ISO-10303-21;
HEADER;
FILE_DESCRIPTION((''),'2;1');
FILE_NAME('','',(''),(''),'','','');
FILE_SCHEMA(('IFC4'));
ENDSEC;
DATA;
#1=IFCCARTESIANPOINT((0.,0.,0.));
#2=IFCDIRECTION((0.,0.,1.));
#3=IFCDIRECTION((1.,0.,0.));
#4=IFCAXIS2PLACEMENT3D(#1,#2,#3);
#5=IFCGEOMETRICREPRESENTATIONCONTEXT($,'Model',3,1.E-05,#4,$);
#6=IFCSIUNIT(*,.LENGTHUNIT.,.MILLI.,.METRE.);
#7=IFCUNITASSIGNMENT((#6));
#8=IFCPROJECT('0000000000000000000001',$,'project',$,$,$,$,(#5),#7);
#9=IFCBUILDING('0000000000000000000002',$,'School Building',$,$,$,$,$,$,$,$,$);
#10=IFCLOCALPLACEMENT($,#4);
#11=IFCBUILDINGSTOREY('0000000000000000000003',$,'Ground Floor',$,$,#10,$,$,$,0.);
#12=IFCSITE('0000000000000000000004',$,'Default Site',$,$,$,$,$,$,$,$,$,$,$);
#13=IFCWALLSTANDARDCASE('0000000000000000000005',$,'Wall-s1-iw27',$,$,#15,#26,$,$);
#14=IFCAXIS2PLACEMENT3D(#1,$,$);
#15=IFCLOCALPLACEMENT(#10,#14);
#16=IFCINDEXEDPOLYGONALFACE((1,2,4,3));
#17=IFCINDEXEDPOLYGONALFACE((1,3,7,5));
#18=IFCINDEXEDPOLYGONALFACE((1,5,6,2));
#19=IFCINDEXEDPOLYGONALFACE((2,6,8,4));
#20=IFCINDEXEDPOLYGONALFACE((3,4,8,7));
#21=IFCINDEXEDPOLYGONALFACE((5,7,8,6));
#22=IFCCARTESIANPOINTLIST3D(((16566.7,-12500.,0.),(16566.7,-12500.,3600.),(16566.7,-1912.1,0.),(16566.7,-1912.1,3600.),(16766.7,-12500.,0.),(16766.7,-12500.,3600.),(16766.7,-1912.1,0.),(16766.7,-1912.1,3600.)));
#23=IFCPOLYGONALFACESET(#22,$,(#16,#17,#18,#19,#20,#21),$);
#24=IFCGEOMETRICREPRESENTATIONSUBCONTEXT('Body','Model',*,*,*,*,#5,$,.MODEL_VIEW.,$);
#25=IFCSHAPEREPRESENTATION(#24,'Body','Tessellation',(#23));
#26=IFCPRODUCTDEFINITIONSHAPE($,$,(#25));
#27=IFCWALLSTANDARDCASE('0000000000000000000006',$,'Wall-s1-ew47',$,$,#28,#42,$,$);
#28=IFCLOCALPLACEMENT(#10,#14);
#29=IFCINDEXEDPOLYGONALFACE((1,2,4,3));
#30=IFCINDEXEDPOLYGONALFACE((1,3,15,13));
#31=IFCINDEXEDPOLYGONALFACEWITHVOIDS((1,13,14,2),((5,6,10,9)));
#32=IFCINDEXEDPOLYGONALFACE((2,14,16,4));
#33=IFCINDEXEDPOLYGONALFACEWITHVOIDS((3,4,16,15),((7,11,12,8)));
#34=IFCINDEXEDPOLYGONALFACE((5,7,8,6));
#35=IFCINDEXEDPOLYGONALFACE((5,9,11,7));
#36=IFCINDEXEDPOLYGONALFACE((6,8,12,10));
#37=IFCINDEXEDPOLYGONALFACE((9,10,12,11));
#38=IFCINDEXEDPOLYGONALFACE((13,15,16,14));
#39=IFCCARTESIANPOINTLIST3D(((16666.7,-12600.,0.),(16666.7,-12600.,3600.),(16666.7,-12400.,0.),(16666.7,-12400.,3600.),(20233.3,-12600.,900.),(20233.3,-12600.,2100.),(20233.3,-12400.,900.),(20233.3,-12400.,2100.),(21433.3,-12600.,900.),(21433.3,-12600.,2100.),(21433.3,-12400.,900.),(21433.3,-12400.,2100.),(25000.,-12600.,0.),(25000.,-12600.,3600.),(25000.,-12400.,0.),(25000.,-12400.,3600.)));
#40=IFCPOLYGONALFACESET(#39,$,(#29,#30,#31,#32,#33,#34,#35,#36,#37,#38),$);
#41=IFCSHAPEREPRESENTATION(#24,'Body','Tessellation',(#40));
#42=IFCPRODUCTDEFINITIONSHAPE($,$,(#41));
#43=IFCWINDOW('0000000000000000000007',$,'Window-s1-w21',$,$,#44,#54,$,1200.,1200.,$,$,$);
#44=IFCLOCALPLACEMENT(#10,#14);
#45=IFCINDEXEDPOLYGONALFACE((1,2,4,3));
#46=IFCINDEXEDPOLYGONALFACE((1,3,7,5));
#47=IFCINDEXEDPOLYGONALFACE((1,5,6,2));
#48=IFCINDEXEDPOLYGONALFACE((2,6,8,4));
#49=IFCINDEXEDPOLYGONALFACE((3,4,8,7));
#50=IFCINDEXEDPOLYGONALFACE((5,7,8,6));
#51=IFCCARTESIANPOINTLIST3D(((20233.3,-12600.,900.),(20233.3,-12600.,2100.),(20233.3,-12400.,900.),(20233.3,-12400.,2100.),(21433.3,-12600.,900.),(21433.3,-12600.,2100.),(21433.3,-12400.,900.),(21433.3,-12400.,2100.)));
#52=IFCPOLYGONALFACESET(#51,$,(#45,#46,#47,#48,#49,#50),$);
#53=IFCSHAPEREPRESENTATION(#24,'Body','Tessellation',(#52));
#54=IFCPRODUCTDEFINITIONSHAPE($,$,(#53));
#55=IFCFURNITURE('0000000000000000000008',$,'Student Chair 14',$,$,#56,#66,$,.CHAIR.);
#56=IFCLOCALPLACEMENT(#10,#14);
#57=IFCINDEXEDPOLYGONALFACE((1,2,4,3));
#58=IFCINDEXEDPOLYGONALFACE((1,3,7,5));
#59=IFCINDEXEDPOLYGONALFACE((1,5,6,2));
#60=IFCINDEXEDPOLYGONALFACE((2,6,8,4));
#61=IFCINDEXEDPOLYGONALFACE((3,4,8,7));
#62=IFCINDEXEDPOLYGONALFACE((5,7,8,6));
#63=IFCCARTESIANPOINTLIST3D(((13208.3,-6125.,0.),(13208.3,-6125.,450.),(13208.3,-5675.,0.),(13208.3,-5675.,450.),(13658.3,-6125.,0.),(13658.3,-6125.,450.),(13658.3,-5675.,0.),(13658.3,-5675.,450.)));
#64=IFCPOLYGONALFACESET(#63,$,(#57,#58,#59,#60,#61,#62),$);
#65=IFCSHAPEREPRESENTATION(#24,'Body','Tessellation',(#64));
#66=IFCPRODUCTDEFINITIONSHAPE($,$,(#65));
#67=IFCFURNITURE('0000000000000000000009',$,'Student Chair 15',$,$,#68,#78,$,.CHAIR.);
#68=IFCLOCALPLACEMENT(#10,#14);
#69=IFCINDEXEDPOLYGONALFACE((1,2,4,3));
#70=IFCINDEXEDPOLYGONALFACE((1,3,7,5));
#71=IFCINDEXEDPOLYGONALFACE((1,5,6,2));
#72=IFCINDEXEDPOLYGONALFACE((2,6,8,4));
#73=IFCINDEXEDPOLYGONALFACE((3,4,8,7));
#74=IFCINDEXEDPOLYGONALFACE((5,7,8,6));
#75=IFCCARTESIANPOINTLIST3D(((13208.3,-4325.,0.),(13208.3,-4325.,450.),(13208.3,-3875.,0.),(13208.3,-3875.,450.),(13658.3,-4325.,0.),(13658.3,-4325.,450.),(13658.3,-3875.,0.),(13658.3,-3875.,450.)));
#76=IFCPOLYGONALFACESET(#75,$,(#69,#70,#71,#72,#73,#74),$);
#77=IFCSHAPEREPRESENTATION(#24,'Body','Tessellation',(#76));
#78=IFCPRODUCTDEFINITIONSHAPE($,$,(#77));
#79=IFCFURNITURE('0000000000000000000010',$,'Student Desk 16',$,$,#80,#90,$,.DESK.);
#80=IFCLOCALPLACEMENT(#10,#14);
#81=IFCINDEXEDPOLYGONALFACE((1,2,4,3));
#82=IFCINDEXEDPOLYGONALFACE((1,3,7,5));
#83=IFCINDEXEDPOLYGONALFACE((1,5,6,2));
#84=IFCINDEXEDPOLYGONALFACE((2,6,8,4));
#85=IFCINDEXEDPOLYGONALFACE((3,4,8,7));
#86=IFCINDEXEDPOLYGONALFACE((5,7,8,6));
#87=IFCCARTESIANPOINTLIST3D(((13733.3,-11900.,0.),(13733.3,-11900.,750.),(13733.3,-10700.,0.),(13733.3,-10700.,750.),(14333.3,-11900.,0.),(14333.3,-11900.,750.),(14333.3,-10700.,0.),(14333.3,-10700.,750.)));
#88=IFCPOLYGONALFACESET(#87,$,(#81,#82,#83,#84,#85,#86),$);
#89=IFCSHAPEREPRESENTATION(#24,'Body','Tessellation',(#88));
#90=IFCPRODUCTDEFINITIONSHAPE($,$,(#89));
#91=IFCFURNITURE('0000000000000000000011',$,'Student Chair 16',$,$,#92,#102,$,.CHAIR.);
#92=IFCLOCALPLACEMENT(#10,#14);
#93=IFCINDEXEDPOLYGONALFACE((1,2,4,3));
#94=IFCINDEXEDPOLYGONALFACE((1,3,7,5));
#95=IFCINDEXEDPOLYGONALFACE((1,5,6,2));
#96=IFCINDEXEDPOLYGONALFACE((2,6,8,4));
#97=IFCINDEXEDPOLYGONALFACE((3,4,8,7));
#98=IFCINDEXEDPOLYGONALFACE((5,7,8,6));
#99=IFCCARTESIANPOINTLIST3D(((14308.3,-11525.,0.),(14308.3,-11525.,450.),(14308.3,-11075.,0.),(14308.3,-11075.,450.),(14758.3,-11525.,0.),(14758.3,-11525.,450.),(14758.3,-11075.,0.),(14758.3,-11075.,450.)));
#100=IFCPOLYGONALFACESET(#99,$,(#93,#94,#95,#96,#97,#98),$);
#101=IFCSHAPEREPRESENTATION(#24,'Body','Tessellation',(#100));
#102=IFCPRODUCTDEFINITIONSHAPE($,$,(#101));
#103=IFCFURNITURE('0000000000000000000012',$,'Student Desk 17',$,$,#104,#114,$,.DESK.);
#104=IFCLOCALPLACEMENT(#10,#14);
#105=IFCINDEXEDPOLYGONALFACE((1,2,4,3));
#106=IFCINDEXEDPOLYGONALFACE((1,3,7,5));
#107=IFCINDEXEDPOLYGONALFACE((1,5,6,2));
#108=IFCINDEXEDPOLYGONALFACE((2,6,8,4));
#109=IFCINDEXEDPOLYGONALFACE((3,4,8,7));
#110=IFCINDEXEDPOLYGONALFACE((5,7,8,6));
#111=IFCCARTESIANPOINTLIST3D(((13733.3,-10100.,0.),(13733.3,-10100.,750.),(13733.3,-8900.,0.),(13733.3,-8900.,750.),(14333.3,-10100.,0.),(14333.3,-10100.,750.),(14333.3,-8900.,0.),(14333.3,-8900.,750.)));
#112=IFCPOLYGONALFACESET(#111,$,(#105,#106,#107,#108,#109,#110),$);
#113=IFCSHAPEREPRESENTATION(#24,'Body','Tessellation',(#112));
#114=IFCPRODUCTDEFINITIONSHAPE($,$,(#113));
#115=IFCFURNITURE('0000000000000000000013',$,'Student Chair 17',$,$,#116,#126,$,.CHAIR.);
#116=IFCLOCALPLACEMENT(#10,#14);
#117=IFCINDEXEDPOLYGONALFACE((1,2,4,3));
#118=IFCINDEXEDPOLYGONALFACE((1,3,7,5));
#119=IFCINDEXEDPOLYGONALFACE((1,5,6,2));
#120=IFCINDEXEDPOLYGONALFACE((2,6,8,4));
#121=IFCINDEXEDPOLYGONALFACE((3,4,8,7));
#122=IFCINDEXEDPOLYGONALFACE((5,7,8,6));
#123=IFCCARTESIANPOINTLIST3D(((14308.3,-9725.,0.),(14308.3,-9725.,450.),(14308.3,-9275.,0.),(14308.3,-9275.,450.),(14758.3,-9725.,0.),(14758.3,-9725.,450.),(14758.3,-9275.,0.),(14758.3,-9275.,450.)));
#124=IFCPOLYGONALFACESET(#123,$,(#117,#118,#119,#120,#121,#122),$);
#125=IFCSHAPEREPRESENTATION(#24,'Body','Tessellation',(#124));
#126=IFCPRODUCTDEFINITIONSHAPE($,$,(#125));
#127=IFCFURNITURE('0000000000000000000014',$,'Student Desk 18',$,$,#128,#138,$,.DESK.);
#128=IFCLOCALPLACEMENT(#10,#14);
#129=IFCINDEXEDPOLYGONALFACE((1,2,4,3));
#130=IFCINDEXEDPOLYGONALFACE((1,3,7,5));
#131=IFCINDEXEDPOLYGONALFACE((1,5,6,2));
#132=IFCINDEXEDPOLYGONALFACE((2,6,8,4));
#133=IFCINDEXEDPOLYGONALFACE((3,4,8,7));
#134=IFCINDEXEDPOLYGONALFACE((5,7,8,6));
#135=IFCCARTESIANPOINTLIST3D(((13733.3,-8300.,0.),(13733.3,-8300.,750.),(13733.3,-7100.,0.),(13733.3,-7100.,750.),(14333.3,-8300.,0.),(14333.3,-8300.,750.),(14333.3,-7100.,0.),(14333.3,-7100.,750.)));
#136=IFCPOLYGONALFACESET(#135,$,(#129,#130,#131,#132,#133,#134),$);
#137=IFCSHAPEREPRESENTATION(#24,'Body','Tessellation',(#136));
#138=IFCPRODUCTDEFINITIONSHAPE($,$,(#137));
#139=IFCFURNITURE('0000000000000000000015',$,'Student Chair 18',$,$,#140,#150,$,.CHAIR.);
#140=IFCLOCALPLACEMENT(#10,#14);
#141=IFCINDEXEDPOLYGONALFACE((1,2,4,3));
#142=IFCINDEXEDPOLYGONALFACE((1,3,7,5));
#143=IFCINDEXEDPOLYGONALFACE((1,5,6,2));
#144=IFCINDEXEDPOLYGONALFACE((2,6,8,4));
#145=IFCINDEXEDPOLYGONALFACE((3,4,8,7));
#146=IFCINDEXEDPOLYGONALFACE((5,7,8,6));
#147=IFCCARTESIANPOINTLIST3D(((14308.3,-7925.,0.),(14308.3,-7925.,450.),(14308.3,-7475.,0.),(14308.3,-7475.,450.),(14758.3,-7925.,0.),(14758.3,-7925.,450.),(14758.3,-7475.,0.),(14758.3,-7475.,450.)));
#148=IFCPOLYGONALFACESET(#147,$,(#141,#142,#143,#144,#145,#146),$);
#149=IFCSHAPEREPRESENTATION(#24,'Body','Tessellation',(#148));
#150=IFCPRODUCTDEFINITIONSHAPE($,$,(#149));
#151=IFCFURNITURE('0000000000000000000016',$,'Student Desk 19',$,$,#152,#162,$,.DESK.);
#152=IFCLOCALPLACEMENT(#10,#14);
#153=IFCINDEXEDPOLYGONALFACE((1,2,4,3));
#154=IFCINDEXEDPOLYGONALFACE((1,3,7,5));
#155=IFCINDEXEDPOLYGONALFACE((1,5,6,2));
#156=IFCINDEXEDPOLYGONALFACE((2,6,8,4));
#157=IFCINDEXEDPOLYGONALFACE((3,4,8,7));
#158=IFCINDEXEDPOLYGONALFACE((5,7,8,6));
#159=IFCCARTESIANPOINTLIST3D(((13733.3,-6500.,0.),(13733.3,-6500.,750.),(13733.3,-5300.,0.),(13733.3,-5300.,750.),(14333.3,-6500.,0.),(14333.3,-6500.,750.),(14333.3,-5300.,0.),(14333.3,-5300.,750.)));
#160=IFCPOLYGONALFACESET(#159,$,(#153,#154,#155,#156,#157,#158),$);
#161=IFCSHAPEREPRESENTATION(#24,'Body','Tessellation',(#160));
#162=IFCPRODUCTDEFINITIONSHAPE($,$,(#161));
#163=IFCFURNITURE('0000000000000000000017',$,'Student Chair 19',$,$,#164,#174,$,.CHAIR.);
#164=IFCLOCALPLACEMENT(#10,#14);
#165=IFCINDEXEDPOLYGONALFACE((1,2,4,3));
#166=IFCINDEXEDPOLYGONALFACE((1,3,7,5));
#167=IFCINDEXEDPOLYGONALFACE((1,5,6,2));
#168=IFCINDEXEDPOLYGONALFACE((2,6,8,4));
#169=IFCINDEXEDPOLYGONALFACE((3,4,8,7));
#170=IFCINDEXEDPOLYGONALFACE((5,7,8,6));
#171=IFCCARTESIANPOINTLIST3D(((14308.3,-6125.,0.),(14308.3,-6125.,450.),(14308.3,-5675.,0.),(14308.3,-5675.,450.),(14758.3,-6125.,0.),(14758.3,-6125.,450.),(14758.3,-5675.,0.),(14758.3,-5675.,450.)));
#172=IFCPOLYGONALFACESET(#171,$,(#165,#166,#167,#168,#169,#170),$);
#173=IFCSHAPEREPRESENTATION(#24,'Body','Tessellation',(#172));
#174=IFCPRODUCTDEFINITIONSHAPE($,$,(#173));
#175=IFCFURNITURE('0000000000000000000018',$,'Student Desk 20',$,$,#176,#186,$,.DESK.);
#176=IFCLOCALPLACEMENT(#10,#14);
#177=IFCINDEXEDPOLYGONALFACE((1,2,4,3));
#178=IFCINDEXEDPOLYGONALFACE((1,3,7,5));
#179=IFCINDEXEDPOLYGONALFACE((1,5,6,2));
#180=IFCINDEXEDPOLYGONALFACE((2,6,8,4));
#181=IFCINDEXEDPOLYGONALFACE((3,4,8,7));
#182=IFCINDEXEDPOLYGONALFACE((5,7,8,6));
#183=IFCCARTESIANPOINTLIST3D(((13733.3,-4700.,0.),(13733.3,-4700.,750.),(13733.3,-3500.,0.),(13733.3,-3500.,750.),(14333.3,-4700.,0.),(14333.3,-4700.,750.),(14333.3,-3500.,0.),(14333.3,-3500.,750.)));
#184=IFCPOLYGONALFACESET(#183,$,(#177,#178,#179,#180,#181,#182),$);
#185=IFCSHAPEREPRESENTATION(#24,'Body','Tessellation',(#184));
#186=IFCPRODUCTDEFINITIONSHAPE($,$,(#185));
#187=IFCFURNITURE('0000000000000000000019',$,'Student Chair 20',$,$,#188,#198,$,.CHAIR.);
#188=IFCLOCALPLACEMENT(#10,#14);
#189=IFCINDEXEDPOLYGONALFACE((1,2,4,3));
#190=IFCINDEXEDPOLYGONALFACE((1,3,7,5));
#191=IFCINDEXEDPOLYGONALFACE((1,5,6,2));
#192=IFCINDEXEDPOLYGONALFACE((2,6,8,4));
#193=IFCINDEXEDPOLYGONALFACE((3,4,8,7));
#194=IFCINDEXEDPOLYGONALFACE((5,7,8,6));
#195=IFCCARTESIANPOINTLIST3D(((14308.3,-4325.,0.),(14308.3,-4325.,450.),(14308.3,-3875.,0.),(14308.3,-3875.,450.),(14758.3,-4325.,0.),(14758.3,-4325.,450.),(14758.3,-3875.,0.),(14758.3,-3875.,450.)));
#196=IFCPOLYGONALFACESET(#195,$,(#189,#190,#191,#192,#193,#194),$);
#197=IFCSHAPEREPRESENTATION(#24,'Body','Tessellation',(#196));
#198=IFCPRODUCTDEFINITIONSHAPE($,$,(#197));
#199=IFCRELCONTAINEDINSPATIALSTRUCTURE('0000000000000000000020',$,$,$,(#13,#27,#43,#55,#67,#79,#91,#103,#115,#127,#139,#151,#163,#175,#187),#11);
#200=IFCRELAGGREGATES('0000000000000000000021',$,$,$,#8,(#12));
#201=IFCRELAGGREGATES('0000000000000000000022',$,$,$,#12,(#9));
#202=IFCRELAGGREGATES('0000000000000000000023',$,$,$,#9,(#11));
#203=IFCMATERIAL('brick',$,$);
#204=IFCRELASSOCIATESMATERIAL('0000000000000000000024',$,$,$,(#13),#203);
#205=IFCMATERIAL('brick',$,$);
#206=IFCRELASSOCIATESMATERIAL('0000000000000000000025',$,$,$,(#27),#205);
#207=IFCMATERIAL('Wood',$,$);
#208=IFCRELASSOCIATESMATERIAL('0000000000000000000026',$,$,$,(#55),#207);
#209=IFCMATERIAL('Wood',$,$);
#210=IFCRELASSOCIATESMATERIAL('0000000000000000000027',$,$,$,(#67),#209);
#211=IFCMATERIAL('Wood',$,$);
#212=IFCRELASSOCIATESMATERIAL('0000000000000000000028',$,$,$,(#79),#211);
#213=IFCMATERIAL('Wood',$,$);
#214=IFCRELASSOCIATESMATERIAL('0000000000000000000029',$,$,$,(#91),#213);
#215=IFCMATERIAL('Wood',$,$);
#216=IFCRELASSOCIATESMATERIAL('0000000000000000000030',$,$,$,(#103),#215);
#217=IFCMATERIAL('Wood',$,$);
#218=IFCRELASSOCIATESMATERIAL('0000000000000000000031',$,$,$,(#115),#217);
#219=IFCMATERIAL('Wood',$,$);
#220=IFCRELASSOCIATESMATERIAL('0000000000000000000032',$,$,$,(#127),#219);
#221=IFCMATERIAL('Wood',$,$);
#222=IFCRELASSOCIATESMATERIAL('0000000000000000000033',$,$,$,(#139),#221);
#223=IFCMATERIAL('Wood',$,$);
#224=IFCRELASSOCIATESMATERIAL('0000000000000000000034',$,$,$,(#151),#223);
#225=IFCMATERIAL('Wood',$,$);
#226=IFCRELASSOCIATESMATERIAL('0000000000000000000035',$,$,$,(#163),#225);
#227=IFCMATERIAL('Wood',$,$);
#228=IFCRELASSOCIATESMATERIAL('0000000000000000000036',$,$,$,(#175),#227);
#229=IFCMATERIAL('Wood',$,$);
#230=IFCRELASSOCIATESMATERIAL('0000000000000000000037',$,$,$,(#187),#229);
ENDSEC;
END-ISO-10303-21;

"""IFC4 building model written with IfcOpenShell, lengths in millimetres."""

from ifc_helpers import new_model, si_unit, frame, frame_2d, origin_with_axes, origin_2d, place, context, subcontext, project, spatial, rectangle, extrude, material, element, fill, save


model = new_model("IFC4")

# Units and contexts
model_context = context("Model", 3, precision=1e-05, world=origin_with_axes())
body_context = subcontext(model_context, "Body", "Model", "MODEL_VIEW")
ifc_project = project(units=[si_unit("LENGTHUNIT", "METRE", prefix="MILLI")], contexts=[model_context])

# Site, building, storey
site = spatial("IfcSite", under=ifc_project, Name="Default Site")
building = spatial("IfcBuilding", under=site, Name="School Building")
storey_placement = place(None, origin_with_axes())
storey = spatial("IfcBuildingStorey", under=building, at=storey_placement, Name="Ground Floor", Elevation=0.0)

# Wall
ifc_material_1 = material(Name="brick")
wall_1_placement = place(storey_placement, frame((16666.7, -12500.0, 0.0), z_axis=(0.0, 0.0, 1.0), x_axis=(0.0, 1.0, 0.0)))
element("IfcWallStandardCase", 1, at=wall_1_placement, inside=storey, material=ifc_material_1, Name="Wall-s1-iw27", context=body_context, shape_type="SweptSolid", body=[
    extrude(rectangle(XDim=10587.9, YDim=200.0, at=frame_2d((5293.9, 0.0))), origin_with_axes(), (0.0, 0.0, 1.0), 3600.0),
])

# Wall, opening, window
ifc_material_2 = material(Name="brick")
wall_2_placement = place(storey_placement, frame((16666.7, -12500.0, 0.0), z_axis=(0.0, 0.0, 1.0), x_axis=(1.0, 0.0, 0.0)))
wall_2 = element("IfcWallStandardCase", 2, at=wall_2_placement, inside=storey, material=ifc_material_2, Name="Wall-s1-ew47", context=body_context, shape_type="SweptSolid", body=[
    extrude(rectangle(XDim=8333.3, YDim=200.0, at=frame_2d((4166.7, 0.0))), origin_with_axes(), (0.0, 0.0, 1.0), 3600.0),
])
opening_placement = place(wall_2_placement, frame((3566.7, 0.0, 900.0), z_axis=(0.0, 0.0, 1.0), x_axis=(1.0, 0.0, 0.0)))
opening = element("IfcOpeningElement", 3, at=opening_placement, cuts=wall_2, context=body_context, shape_type="SweptSolid", body=[
    extrude(rectangle(XDim=1200.0, YDim=400.0, at=frame_2d((600.0, 0.0))), origin_with_axes(), (0.0, 0.0, 1.0), 1200.0),
])
window_placement = place(storey_placement, frame((20233.3, -12500.0, 900.0), z_axis=(0.0, 0.0, 1.0), x_axis=(1.0, 0.0, 0.0)))
window = element("IfcWindow", 4, at=window_placement, inside=storey, Name="Window-s1-w21", OverallHeight=1200.0, OverallWidth=1200.0, context=body_context, shape_type="SweptSolid", body=[
    extrude(rectangle(XDim=1200.0, YDim=200.0, at=frame_2d((600.0, 0.0))), origin_with_axes(), (0.0, 0.0, 1.0), 1200.0),
])
fill(opening, window)

# Furniture
ifc_material_3 = material(Name="Wood")
furniture_1_placement = place(storey_placement, frame((13433.3, -5900.0, 0.0), z_axis=(0.0, 0.0, 1.0), x_axis=(1.0, 0.0, 0.0)))
element("IfcFurniture", 5, at=furniture_1_placement, inside=storey, material=ifc_material_3, Name="Student Chair 14", PredefinedType="CHAIR", context=body_context, shape_type="SweptSolid", body=[
    extrude(rectangle(XDim=450.0, YDim=450.0, at=origin_2d()), origin_with_axes(), (0.0, 0.0, 1.0), 450.0),
])
ifc_material_4 = material(Name="Wood")
furniture_2_placement = place(storey_placement, frame((13433.3, -4100.0, 0.0), z_axis=(0.0, 0.0, 1.0), x_axis=(1.0, 0.0, 0.0)))
element("IfcFurniture", 6, at=furniture_2_placement, inside=storey, material=ifc_material_4, Name="Student Chair 15", PredefinedType="CHAIR", context=body_context, shape_type="SweptSolid", body=[
    extrude(rectangle(XDim=450.0, YDim=450.0, at=origin_2d()), origin_with_axes(), (0.0, 0.0, 1.0), 450.0),
])
ifc_material_5 = material(Name="Wood")
furniture_3_placement = place(storey_placement, frame((14033.3, -11300.0, 0.0), z_axis=(0.0, 0.0, 1.0), x_axis=(0.0, 1.0, 0.0)))
element("IfcFurniture", 7, at=furniture_3_placement, inside=storey, material=ifc_material_5, Name="Student Desk 16", PredefinedType="DESK", context=body_context, shape_type="SweptSolid", body=[
    extrude(rectangle(XDim=1200.0, YDim=600.0, at=origin_2d()), origin_with_axes(), (0.0, 0.0, 1.0), 750.0),
])
ifc_material_6 = material(Name="Wood")
furniture_4_placement = place(storey_placement, frame((14533.3, -11300.0, 0.0), z_axis=(0.0, 0.0, 1.0), x_axis=(1.0, 0.0, 0.0)))
element("IfcFurniture", 8, at=furniture_4_placement, inside=storey, material=ifc_material_6, Name="Student Chair 16", PredefinedType="CHAIR", context=body_context, shape_type="SweptSolid", body=[
    extrude(rectangle(XDim=450.0, YDim=450.0, at=origin_2d()), origin_with_axes(), (0.0, 0.0, 1.0), 450.0),
])
ifc_material_7 = material(Name="Wood")
furniture_5_placement = place(storey_placement, frame((14033.3, -9500.0, 0.0), z_axis=(0.0, 0.0, 1.0), x_axis=(0.0, 1.0, 0.0)))
element("IfcFurniture", 9, at=furniture_5_placement, inside=storey, material=ifc_material_7, Name="Student Desk 17", PredefinedType="DESK", context=body_context, shape_type="SweptSolid", body=[
    extrude(rectangle(XDim=1200.0, YDim=600.0, at=origin_2d()), origin_with_axes(), (0.0, 0.0, 1.0), 750.0),
])
ifc_material_8 = material(Name="Wood")
furniture_6_placement = place(storey_placement, frame((14533.3, -9500.0, 0.0), z_axis=(0.0, 0.0, 1.0), x_axis=(1.0, 0.0, 0.0)))
element("IfcFurniture", 10, at=furniture_6_placement, inside=storey, material=ifc_material_8, Name="Student Chair 17", PredefinedType="CHAIR", context=body_context, shape_type="SweptSolid", body=[
    extrude(rectangle(XDim=450.0, YDim=450.0, at=origin_2d()), origin_with_axes(), (0.0, 0.0, 1.0), 450.0),
])
ifc_material_9 = material(Name="Wood")
furniture_7_placement = place(storey_placement, frame((14033.3, -7700.0, 0.0), z_axis=(0.0, 0.0, 1.0), x_axis=(0.0, 1.0, 0.0)))
element("IfcFurniture", 11, at=furniture_7_placement, inside=storey, material=ifc_material_9, Name="Student Desk 18", PredefinedType="DESK", context=body_context, shape_type="SweptSolid", body=[
    extrude(rectangle(XDim=1200.0, YDim=600.0, at=origin_2d()), origin_with_axes(), (0.0, 0.0, 1.0), 750.0),
])
ifc_material_10 = material(Name="Wood")
furniture_8_placement = place(storey_placement, frame((14533.3, -7700.0, 0.0), z_axis=(0.0, 0.0, 1.0), x_axis=(1.0, 0.0, 0.0)))
element("IfcFurniture", 12, at=furniture_8_placement, inside=storey, material=ifc_material_10, Name="Student Chair 18", PredefinedType="CHAIR", context=body_context, shape_type="SweptSolid", body=[
    extrude(rectangle(XDim=450.0, YDim=450.0, at=origin_2d()), origin_with_axes(), (0.0, 0.0, 1.0), 450.0),
])
ifc_material_11 = material(Name="Wood")
furniture_9_placement = place(storey_placement, frame((14033.3, -5900.0, 0.0), z_axis=(0.0, 0.0, 1.0), x_axis=(0.0, 1.0, 0.0)))
element("IfcFurniture", 13, at=furniture_9_placement, inside=storey, material=ifc_material_11, Name="Student Desk 19", PredefinedType="DESK", context=body_context, shape_type="SweptSolid", body=[
    extrude(rectangle(XDim=1200.0, YDim=600.0, at=origin_2d()), origin_with_axes(), (0.0, 0.0, 1.0), 750.0),
])
ifc_material_12 = material(Name="Wood")
furniture_10_placement = place(storey_placement, frame((14533.3, -5900.0, 0.0), z_axis=(0.0, 0.0, 1.0), x_axis=(1.0, 0.0, 0.0)))
element("IfcFurniture", 14, at=furniture_10_placement, inside=storey, material=ifc_material_12, Name="Student Chair 19", PredefinedType="CHAIR", context=body_context, shape_type="SweptSolid", body=[
    extrude(rectangle(XDim=450.0, YDim=450.0, at=origin_2d()), origin_with_axes(), (0.0, 0.0, 1.0), 450.0),
])
ifc_material_13 = material(Name="Wood")
furniture_11_placement = place(storey_placement, frame((14033.3, -4100.0, 0.0), z_axis=(0.0, 0.0, 1.0), x_axis=(0.0, 1.0, 0.0)))
element("IfcFurniture", 15, at=furniture_11_placement, inside=storey, material=ifc_material_13, Name="Student Desk 20", PredefinedType="DESK", context=body_context, shape_type="SweptSolid", body=[
    extrude(rectangle(XDim=1200.0, YDim=600.0, at=origin_2d()), origin_with_axes(), (0.0, 0.0, 1.0), 750.0),
])
ifc_material_14 = material(Name="Wood")
furniture_12_placement = place(storey_placement, frame((14533.3, -4100.0, 0.0), z_axis=(0.0, 0.0, 1.0), x_axis=(1.0, 0.0, 0.0)))
element("IfcFurniture", 16, at=furniture_12_placement, inside=storey, material=ifc_material_14, Name="Student Chair 20", PredefinedType="CHAIR", context=body_context, shape_type="SweptSolid", body=[
    extrude(rectangle(XDim=450.0, YDim=450.0, at=origin_2d()), origin_with_axes(), (0.0, 0.0, 1.0), 450.0),
])

save(model, "model.ifc")
